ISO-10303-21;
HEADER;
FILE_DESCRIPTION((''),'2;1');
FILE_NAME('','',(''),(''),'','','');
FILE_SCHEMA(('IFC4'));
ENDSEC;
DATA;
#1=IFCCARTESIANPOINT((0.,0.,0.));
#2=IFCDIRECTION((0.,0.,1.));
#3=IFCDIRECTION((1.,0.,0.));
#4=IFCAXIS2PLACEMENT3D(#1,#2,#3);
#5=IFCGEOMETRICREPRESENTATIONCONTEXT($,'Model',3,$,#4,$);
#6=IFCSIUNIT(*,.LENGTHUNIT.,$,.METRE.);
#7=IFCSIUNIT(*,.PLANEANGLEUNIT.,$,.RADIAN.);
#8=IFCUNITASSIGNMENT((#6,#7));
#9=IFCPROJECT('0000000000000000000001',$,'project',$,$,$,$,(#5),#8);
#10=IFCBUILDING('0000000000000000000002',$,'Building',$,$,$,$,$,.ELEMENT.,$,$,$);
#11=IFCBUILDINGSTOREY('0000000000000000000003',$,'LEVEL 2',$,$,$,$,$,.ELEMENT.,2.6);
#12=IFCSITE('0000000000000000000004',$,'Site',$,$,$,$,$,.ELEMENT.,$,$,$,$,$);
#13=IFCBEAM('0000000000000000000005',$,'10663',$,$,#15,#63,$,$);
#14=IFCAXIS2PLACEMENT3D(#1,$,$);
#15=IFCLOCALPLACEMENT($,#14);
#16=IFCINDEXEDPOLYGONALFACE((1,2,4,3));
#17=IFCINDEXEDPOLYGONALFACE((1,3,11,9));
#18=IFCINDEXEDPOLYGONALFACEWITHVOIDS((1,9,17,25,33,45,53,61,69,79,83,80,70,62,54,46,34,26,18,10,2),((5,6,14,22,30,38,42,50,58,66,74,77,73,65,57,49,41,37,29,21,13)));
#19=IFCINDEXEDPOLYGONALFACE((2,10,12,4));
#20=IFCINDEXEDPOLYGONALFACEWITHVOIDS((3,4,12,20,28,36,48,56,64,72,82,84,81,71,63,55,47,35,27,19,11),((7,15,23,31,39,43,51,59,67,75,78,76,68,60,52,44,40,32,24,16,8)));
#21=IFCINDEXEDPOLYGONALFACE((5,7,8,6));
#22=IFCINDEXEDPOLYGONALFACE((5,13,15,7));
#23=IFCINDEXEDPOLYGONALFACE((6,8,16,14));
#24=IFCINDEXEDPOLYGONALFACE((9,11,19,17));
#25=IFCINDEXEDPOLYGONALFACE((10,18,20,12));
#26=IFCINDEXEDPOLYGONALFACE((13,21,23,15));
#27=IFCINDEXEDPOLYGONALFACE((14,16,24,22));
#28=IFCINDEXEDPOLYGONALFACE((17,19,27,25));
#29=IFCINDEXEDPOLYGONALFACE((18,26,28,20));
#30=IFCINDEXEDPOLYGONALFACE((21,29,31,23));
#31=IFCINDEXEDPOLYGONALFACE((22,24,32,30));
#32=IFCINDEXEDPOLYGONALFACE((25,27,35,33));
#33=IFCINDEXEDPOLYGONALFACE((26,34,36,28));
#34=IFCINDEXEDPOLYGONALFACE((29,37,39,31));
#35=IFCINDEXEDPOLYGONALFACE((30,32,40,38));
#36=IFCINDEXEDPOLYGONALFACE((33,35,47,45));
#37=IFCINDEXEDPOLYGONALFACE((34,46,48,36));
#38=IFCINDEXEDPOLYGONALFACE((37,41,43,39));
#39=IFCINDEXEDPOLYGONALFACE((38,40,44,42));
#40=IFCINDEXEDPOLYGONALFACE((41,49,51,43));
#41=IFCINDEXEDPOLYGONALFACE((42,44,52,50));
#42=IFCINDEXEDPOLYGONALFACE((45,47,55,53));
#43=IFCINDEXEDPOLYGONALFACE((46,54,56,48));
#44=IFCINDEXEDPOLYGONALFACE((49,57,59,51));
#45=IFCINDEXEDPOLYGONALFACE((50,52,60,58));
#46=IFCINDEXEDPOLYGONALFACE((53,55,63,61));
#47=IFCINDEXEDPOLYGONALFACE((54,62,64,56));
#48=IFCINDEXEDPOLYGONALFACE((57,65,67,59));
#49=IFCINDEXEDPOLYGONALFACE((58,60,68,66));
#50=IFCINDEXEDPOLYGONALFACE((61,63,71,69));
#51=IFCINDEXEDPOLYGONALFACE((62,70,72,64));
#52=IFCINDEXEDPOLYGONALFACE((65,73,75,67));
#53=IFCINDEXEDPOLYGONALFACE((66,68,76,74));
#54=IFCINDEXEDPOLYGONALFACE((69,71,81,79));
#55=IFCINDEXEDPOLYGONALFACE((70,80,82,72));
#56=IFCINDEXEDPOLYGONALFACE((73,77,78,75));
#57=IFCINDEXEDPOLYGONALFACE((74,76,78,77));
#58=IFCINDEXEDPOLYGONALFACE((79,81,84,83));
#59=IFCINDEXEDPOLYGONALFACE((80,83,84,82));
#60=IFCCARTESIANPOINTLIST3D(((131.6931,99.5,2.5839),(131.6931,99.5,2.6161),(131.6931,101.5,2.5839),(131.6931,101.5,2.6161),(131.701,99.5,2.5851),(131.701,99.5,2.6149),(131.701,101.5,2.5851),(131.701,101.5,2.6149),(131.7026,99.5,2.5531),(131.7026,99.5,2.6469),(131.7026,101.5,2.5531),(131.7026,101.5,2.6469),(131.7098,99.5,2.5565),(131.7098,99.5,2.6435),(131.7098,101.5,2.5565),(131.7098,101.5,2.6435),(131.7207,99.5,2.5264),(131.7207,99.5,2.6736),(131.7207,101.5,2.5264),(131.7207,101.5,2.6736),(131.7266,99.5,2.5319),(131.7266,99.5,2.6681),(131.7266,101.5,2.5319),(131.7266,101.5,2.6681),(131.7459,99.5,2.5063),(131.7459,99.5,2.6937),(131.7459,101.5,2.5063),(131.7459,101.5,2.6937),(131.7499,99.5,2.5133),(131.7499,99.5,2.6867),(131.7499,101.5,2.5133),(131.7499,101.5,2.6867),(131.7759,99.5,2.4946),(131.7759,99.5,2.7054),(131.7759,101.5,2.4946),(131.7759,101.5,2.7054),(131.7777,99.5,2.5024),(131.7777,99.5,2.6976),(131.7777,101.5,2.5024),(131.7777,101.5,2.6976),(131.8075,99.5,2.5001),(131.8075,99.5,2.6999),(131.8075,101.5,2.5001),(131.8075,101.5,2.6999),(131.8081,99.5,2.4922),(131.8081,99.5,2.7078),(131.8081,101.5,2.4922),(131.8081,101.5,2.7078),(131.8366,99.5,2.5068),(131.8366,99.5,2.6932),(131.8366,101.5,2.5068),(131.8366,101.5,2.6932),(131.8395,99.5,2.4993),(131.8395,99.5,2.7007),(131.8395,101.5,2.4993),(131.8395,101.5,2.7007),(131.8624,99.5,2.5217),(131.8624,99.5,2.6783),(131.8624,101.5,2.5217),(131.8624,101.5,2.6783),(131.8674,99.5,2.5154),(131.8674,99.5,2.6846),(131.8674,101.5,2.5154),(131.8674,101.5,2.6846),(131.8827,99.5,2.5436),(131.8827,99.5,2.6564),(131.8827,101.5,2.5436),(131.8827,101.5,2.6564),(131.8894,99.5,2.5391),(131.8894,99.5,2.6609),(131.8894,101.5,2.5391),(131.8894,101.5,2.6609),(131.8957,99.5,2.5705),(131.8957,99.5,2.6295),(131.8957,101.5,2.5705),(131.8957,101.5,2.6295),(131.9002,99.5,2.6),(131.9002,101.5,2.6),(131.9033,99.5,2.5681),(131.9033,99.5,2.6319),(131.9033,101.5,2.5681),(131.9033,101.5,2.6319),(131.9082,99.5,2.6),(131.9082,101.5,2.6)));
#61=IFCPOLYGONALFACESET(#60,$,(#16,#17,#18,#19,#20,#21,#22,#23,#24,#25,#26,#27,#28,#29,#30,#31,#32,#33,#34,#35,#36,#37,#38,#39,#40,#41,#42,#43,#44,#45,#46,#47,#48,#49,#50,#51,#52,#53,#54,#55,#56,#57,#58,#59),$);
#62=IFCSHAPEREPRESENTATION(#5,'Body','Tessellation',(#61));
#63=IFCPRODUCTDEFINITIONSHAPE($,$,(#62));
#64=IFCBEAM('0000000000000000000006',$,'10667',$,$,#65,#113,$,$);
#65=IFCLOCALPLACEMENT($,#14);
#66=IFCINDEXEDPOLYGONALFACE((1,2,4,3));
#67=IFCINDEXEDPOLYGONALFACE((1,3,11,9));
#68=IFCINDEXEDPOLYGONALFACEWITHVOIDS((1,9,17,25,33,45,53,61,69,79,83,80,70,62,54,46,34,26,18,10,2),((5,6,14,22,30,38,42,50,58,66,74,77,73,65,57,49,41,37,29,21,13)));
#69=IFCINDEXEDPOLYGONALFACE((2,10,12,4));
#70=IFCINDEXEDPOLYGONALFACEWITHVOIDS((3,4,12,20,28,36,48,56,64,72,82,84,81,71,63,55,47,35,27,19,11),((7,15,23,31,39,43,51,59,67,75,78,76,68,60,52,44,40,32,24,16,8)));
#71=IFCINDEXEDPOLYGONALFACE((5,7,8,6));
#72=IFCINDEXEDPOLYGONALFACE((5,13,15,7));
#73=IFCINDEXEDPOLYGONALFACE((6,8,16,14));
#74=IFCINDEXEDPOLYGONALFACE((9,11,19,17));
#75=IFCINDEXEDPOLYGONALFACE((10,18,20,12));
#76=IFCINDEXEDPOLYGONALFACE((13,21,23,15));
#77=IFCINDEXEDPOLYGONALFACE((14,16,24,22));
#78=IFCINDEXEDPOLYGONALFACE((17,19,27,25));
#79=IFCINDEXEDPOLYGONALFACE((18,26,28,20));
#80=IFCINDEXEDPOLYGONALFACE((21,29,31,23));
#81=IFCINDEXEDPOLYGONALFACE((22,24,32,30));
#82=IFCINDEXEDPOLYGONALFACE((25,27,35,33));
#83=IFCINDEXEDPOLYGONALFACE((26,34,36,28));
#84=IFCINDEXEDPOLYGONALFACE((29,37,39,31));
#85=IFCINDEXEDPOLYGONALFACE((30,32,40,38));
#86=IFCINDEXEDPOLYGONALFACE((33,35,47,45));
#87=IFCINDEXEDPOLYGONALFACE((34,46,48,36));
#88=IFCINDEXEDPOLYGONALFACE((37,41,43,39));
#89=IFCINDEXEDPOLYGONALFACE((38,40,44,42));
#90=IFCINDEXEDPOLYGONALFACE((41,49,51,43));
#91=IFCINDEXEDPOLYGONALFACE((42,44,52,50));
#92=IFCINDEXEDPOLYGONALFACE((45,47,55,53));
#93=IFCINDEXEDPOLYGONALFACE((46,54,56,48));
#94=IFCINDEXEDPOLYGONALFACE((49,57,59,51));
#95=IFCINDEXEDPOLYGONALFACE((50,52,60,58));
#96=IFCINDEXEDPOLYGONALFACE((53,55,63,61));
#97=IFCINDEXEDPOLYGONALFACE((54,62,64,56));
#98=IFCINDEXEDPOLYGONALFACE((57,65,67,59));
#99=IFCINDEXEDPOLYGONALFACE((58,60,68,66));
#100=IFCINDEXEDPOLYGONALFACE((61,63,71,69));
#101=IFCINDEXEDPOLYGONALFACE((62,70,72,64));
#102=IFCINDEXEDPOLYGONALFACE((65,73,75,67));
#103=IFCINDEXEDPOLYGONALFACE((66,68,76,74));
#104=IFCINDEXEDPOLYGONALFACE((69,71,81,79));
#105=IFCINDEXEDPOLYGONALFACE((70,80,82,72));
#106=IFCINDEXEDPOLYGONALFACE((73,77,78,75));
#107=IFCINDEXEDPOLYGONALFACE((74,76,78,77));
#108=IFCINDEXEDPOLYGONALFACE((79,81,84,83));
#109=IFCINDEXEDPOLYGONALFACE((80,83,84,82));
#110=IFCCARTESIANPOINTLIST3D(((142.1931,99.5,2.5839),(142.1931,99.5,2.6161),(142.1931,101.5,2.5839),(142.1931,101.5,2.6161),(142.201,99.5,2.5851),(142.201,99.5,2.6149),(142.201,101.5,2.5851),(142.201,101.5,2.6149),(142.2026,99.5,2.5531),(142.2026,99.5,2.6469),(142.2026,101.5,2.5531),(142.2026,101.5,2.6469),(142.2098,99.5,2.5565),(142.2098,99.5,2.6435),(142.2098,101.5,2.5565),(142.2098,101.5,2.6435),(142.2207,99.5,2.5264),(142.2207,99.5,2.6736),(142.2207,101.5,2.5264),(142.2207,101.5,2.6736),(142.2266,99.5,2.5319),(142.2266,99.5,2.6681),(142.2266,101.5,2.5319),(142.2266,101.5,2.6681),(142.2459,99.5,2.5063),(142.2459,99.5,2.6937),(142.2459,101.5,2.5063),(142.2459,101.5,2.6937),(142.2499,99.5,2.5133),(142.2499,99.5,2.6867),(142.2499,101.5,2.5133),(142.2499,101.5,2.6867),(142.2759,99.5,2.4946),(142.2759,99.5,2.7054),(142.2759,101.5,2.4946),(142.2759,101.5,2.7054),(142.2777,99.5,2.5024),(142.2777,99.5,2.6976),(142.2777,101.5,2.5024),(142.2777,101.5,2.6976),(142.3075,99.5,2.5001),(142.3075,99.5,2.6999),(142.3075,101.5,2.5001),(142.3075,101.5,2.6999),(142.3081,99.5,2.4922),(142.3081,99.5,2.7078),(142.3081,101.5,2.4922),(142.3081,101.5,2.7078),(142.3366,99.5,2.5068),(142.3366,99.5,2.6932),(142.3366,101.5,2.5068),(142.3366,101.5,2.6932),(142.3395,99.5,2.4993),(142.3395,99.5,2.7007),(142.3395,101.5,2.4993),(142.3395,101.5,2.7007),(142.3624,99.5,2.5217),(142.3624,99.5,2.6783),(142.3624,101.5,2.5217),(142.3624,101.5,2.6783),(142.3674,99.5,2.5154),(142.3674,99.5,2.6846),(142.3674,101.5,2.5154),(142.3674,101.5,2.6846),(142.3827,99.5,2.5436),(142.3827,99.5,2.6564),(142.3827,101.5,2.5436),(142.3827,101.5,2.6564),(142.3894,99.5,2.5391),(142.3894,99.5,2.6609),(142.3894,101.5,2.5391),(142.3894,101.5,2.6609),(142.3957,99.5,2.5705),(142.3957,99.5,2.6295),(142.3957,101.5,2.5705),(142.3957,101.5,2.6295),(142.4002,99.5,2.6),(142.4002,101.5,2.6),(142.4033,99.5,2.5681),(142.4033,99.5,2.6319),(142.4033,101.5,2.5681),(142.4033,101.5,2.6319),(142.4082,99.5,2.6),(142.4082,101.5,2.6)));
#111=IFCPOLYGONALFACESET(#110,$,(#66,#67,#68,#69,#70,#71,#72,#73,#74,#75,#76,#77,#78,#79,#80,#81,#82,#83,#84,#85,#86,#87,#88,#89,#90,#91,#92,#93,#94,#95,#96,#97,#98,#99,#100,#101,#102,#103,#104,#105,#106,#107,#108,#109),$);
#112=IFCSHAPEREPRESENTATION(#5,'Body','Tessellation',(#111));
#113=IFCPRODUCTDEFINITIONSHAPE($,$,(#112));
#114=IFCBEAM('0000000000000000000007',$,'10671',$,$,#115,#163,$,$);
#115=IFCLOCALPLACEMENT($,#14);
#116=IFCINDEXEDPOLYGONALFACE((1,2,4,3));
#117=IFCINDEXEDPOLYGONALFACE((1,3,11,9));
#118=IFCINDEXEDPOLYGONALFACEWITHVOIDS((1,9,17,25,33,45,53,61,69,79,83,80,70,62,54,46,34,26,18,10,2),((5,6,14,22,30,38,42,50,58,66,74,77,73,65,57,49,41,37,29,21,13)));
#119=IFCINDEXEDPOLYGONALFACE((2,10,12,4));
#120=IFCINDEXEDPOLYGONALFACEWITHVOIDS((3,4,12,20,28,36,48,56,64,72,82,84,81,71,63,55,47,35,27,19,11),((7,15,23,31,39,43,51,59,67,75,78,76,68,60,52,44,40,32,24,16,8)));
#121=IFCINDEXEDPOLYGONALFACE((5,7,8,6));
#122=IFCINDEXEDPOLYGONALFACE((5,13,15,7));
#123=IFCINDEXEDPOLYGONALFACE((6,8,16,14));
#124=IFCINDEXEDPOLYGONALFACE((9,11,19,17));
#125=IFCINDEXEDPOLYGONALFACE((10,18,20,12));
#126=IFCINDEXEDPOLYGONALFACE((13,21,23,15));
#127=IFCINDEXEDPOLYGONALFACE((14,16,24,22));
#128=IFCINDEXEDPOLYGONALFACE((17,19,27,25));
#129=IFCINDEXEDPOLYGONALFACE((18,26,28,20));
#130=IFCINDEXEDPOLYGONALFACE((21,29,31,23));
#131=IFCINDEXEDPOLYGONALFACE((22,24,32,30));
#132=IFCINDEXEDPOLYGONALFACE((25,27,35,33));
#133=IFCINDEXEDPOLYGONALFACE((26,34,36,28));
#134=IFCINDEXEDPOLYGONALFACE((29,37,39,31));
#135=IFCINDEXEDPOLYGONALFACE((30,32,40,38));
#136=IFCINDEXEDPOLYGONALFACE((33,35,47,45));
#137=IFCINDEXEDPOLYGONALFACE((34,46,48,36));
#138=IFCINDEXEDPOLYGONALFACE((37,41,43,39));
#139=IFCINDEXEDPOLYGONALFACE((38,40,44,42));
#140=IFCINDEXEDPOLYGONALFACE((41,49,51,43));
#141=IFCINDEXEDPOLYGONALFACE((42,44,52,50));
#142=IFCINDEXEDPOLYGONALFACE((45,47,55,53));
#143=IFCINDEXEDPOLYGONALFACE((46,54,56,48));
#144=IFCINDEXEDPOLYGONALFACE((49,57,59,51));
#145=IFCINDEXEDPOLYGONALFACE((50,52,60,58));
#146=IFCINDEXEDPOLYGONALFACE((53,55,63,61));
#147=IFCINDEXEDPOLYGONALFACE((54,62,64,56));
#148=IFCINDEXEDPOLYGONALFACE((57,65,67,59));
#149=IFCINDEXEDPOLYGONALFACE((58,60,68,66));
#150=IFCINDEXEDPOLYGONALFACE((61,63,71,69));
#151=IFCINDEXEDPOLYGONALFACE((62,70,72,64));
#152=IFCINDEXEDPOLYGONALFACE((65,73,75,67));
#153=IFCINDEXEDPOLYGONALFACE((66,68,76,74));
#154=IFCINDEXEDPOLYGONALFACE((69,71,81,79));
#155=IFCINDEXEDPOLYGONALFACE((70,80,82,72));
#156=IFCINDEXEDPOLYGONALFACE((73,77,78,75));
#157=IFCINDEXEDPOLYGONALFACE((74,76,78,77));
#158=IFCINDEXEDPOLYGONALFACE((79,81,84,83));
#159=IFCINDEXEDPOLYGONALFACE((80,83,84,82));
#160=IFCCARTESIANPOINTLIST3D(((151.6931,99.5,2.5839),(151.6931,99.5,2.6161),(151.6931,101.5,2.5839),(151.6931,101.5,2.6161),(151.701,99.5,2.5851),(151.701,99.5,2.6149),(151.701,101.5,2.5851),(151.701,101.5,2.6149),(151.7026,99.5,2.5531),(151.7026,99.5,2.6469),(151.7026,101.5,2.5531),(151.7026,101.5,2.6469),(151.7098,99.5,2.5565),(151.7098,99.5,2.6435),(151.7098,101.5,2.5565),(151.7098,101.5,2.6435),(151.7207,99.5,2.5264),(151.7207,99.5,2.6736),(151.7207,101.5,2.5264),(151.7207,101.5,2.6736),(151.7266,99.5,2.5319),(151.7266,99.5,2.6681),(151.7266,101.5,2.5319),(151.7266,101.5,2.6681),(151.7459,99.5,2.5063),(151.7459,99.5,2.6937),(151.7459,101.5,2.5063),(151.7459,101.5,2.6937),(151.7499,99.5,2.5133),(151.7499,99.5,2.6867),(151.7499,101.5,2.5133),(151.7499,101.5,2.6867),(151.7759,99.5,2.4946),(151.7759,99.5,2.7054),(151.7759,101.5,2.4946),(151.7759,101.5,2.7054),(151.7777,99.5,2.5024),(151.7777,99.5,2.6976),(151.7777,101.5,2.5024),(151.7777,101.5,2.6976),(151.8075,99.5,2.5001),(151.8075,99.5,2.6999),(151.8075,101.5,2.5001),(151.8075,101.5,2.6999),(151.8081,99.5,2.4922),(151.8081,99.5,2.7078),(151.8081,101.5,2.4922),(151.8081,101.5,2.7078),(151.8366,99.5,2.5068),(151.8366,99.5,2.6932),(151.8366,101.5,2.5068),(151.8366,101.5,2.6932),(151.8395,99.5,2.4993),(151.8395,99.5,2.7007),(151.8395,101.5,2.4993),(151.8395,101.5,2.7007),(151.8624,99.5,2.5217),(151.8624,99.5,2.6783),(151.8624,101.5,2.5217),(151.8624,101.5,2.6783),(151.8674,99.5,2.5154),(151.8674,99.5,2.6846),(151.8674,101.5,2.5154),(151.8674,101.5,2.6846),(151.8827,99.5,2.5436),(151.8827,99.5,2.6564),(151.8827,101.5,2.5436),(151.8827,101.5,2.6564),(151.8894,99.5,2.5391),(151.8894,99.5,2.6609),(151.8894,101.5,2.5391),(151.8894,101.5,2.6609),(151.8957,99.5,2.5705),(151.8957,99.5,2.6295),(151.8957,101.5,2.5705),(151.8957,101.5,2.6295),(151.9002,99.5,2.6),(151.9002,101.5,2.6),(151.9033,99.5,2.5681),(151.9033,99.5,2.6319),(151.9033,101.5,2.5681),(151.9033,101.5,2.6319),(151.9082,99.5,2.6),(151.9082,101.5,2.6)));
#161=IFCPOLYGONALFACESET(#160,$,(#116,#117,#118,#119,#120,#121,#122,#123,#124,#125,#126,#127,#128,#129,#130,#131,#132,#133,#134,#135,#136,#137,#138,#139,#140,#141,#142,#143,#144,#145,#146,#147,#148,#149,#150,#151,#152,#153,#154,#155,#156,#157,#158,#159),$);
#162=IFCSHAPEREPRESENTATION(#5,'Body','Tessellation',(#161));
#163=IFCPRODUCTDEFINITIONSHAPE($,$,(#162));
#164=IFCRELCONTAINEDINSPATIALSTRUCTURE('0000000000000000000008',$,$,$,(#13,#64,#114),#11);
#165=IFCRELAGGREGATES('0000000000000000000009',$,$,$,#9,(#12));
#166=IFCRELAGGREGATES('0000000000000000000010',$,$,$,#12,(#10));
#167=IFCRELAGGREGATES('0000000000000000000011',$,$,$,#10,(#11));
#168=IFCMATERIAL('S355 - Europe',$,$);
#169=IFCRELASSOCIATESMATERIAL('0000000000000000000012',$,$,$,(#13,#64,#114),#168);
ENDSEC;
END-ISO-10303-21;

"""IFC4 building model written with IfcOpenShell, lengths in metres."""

from ifc_helpers import new_model, si_unit, frame, origin_with_axes, origin_2d_with_axis, place, context, project, spatial, hollow_circle, extrude, material, material_profile, profile_set, profile_usage, element, save


model = new_model("IFC4")

# Units and contexts
model_context = context("Model", 3, world=origin_with_axes())
ifc_project = project(units=[si_unit("LENGTHUNIT", "METRE"), si_unit("PLANEANGLEUNIT", "RADIAN")], contexts=[model_context])

# Site, building, storey
site = spatial("IfcSite", under=ifc_project, Name="Site", CompositionType="ELEMENT")
building = spatial("IfcBuilding", under=site, Name="Building", CompositionType="ELEMENT")
storey = spatial("IfcBuildingStorey", under=building, Name="LEVEL 2", CompositionType="ELEMENT", Elevation=2.6)

# Shared definitions
ifc_material = material(Name="S355 - Europe")

# Beams
ifc_material_profile_1 = material_profile(ifc_material, hollow_circle(Radius=0.1081, WallThickness=0.008, at=origin_2d_with_axis()))
ifc_profile_set_1 = profile_set([ifc_material_profile_1])
ifc_profile_usage_1 = profile_usage(ifc_profile_set_1, cardinal=10)
beam_1_placement = place(None, frame((131.8, 101.5, 2.6), z_axis=(0.0, -1.0, 0.0), x_axis=(1.0, 0.0, 0.0)))
element("IfcBeam", 1, at=beam_1_placement, inside=storey, material=ifc_profile_usage_1, Name="10663", context=model_context, shape_type="SweptSolid", body=[
    extrude(hollow_circle(Radius=0.1081, WallThickness=0.008, at=origin_2d_with_axis()), origin_with_axes(), (0.0, 0.0, 1.0), 2.0),
])
ifc_material_profile_2 = material_profile(ifc_material, hollow_circle(Radius=0.1081, WallThickness=0.008, at=origin_2d_with_axis()))
ifc_profile_set_2 = profile_set([ifc_material_profile_2])
ifc_profile_usage_2 = profile_usage(ifc_profile_set_2, cardinal=10)
beam_2_placement = place(None, frame((142.3, 101.5, 2.6), z_axis=(0.0, -1.0, 0.0), x_axis=(1.0, 0.0, 0.0)))
element("IfcBeam", 2, at=beam_2_placement, inside=storey, material=ifc_profile_usage_2, Name="10667", context=model_context, shape_type="SweptSolid", body=[
    extrude(hollow_circle(Radius=0.1081, WallThickness=0.008, at=origin_2d_with_axis()), origin_with_axes(), (0.0, 0.0, 1.0), 2.0),
])
ifc_material_profile_3 = material_profile(ifc_material, hollow_circle(Radius=0.1081, WallThickness=0.008, at=origin_2d_with_axis()))
ifc_profile_set_3 = profile_set([ifc_material_profile_3])
ifc_profile_usage_3 = profile_usage(ifc_profile_set_3, cardinal=10)
beam_3_placement = place(None, frame((151.8, 101.5, 2.6), z_axis=(0.0, -1.0, 0.0), x_axis=(1.0, 0.0, 0.0)))
element("IfcBeam", 3, at=beam_3_placement, inside=storey, material=ifc_profile_usage_3, Name="10671", context=model_context, shape_type="SweptSolid", body=[
    extrude(hollow_circle(Radius=0.1081, WallThickness=0.008, at=origin_2d_with_axis()), origin_with_axes(), (0.0, 0.0, 1.0), 2.0),
])

save(model, "model.ifc")
